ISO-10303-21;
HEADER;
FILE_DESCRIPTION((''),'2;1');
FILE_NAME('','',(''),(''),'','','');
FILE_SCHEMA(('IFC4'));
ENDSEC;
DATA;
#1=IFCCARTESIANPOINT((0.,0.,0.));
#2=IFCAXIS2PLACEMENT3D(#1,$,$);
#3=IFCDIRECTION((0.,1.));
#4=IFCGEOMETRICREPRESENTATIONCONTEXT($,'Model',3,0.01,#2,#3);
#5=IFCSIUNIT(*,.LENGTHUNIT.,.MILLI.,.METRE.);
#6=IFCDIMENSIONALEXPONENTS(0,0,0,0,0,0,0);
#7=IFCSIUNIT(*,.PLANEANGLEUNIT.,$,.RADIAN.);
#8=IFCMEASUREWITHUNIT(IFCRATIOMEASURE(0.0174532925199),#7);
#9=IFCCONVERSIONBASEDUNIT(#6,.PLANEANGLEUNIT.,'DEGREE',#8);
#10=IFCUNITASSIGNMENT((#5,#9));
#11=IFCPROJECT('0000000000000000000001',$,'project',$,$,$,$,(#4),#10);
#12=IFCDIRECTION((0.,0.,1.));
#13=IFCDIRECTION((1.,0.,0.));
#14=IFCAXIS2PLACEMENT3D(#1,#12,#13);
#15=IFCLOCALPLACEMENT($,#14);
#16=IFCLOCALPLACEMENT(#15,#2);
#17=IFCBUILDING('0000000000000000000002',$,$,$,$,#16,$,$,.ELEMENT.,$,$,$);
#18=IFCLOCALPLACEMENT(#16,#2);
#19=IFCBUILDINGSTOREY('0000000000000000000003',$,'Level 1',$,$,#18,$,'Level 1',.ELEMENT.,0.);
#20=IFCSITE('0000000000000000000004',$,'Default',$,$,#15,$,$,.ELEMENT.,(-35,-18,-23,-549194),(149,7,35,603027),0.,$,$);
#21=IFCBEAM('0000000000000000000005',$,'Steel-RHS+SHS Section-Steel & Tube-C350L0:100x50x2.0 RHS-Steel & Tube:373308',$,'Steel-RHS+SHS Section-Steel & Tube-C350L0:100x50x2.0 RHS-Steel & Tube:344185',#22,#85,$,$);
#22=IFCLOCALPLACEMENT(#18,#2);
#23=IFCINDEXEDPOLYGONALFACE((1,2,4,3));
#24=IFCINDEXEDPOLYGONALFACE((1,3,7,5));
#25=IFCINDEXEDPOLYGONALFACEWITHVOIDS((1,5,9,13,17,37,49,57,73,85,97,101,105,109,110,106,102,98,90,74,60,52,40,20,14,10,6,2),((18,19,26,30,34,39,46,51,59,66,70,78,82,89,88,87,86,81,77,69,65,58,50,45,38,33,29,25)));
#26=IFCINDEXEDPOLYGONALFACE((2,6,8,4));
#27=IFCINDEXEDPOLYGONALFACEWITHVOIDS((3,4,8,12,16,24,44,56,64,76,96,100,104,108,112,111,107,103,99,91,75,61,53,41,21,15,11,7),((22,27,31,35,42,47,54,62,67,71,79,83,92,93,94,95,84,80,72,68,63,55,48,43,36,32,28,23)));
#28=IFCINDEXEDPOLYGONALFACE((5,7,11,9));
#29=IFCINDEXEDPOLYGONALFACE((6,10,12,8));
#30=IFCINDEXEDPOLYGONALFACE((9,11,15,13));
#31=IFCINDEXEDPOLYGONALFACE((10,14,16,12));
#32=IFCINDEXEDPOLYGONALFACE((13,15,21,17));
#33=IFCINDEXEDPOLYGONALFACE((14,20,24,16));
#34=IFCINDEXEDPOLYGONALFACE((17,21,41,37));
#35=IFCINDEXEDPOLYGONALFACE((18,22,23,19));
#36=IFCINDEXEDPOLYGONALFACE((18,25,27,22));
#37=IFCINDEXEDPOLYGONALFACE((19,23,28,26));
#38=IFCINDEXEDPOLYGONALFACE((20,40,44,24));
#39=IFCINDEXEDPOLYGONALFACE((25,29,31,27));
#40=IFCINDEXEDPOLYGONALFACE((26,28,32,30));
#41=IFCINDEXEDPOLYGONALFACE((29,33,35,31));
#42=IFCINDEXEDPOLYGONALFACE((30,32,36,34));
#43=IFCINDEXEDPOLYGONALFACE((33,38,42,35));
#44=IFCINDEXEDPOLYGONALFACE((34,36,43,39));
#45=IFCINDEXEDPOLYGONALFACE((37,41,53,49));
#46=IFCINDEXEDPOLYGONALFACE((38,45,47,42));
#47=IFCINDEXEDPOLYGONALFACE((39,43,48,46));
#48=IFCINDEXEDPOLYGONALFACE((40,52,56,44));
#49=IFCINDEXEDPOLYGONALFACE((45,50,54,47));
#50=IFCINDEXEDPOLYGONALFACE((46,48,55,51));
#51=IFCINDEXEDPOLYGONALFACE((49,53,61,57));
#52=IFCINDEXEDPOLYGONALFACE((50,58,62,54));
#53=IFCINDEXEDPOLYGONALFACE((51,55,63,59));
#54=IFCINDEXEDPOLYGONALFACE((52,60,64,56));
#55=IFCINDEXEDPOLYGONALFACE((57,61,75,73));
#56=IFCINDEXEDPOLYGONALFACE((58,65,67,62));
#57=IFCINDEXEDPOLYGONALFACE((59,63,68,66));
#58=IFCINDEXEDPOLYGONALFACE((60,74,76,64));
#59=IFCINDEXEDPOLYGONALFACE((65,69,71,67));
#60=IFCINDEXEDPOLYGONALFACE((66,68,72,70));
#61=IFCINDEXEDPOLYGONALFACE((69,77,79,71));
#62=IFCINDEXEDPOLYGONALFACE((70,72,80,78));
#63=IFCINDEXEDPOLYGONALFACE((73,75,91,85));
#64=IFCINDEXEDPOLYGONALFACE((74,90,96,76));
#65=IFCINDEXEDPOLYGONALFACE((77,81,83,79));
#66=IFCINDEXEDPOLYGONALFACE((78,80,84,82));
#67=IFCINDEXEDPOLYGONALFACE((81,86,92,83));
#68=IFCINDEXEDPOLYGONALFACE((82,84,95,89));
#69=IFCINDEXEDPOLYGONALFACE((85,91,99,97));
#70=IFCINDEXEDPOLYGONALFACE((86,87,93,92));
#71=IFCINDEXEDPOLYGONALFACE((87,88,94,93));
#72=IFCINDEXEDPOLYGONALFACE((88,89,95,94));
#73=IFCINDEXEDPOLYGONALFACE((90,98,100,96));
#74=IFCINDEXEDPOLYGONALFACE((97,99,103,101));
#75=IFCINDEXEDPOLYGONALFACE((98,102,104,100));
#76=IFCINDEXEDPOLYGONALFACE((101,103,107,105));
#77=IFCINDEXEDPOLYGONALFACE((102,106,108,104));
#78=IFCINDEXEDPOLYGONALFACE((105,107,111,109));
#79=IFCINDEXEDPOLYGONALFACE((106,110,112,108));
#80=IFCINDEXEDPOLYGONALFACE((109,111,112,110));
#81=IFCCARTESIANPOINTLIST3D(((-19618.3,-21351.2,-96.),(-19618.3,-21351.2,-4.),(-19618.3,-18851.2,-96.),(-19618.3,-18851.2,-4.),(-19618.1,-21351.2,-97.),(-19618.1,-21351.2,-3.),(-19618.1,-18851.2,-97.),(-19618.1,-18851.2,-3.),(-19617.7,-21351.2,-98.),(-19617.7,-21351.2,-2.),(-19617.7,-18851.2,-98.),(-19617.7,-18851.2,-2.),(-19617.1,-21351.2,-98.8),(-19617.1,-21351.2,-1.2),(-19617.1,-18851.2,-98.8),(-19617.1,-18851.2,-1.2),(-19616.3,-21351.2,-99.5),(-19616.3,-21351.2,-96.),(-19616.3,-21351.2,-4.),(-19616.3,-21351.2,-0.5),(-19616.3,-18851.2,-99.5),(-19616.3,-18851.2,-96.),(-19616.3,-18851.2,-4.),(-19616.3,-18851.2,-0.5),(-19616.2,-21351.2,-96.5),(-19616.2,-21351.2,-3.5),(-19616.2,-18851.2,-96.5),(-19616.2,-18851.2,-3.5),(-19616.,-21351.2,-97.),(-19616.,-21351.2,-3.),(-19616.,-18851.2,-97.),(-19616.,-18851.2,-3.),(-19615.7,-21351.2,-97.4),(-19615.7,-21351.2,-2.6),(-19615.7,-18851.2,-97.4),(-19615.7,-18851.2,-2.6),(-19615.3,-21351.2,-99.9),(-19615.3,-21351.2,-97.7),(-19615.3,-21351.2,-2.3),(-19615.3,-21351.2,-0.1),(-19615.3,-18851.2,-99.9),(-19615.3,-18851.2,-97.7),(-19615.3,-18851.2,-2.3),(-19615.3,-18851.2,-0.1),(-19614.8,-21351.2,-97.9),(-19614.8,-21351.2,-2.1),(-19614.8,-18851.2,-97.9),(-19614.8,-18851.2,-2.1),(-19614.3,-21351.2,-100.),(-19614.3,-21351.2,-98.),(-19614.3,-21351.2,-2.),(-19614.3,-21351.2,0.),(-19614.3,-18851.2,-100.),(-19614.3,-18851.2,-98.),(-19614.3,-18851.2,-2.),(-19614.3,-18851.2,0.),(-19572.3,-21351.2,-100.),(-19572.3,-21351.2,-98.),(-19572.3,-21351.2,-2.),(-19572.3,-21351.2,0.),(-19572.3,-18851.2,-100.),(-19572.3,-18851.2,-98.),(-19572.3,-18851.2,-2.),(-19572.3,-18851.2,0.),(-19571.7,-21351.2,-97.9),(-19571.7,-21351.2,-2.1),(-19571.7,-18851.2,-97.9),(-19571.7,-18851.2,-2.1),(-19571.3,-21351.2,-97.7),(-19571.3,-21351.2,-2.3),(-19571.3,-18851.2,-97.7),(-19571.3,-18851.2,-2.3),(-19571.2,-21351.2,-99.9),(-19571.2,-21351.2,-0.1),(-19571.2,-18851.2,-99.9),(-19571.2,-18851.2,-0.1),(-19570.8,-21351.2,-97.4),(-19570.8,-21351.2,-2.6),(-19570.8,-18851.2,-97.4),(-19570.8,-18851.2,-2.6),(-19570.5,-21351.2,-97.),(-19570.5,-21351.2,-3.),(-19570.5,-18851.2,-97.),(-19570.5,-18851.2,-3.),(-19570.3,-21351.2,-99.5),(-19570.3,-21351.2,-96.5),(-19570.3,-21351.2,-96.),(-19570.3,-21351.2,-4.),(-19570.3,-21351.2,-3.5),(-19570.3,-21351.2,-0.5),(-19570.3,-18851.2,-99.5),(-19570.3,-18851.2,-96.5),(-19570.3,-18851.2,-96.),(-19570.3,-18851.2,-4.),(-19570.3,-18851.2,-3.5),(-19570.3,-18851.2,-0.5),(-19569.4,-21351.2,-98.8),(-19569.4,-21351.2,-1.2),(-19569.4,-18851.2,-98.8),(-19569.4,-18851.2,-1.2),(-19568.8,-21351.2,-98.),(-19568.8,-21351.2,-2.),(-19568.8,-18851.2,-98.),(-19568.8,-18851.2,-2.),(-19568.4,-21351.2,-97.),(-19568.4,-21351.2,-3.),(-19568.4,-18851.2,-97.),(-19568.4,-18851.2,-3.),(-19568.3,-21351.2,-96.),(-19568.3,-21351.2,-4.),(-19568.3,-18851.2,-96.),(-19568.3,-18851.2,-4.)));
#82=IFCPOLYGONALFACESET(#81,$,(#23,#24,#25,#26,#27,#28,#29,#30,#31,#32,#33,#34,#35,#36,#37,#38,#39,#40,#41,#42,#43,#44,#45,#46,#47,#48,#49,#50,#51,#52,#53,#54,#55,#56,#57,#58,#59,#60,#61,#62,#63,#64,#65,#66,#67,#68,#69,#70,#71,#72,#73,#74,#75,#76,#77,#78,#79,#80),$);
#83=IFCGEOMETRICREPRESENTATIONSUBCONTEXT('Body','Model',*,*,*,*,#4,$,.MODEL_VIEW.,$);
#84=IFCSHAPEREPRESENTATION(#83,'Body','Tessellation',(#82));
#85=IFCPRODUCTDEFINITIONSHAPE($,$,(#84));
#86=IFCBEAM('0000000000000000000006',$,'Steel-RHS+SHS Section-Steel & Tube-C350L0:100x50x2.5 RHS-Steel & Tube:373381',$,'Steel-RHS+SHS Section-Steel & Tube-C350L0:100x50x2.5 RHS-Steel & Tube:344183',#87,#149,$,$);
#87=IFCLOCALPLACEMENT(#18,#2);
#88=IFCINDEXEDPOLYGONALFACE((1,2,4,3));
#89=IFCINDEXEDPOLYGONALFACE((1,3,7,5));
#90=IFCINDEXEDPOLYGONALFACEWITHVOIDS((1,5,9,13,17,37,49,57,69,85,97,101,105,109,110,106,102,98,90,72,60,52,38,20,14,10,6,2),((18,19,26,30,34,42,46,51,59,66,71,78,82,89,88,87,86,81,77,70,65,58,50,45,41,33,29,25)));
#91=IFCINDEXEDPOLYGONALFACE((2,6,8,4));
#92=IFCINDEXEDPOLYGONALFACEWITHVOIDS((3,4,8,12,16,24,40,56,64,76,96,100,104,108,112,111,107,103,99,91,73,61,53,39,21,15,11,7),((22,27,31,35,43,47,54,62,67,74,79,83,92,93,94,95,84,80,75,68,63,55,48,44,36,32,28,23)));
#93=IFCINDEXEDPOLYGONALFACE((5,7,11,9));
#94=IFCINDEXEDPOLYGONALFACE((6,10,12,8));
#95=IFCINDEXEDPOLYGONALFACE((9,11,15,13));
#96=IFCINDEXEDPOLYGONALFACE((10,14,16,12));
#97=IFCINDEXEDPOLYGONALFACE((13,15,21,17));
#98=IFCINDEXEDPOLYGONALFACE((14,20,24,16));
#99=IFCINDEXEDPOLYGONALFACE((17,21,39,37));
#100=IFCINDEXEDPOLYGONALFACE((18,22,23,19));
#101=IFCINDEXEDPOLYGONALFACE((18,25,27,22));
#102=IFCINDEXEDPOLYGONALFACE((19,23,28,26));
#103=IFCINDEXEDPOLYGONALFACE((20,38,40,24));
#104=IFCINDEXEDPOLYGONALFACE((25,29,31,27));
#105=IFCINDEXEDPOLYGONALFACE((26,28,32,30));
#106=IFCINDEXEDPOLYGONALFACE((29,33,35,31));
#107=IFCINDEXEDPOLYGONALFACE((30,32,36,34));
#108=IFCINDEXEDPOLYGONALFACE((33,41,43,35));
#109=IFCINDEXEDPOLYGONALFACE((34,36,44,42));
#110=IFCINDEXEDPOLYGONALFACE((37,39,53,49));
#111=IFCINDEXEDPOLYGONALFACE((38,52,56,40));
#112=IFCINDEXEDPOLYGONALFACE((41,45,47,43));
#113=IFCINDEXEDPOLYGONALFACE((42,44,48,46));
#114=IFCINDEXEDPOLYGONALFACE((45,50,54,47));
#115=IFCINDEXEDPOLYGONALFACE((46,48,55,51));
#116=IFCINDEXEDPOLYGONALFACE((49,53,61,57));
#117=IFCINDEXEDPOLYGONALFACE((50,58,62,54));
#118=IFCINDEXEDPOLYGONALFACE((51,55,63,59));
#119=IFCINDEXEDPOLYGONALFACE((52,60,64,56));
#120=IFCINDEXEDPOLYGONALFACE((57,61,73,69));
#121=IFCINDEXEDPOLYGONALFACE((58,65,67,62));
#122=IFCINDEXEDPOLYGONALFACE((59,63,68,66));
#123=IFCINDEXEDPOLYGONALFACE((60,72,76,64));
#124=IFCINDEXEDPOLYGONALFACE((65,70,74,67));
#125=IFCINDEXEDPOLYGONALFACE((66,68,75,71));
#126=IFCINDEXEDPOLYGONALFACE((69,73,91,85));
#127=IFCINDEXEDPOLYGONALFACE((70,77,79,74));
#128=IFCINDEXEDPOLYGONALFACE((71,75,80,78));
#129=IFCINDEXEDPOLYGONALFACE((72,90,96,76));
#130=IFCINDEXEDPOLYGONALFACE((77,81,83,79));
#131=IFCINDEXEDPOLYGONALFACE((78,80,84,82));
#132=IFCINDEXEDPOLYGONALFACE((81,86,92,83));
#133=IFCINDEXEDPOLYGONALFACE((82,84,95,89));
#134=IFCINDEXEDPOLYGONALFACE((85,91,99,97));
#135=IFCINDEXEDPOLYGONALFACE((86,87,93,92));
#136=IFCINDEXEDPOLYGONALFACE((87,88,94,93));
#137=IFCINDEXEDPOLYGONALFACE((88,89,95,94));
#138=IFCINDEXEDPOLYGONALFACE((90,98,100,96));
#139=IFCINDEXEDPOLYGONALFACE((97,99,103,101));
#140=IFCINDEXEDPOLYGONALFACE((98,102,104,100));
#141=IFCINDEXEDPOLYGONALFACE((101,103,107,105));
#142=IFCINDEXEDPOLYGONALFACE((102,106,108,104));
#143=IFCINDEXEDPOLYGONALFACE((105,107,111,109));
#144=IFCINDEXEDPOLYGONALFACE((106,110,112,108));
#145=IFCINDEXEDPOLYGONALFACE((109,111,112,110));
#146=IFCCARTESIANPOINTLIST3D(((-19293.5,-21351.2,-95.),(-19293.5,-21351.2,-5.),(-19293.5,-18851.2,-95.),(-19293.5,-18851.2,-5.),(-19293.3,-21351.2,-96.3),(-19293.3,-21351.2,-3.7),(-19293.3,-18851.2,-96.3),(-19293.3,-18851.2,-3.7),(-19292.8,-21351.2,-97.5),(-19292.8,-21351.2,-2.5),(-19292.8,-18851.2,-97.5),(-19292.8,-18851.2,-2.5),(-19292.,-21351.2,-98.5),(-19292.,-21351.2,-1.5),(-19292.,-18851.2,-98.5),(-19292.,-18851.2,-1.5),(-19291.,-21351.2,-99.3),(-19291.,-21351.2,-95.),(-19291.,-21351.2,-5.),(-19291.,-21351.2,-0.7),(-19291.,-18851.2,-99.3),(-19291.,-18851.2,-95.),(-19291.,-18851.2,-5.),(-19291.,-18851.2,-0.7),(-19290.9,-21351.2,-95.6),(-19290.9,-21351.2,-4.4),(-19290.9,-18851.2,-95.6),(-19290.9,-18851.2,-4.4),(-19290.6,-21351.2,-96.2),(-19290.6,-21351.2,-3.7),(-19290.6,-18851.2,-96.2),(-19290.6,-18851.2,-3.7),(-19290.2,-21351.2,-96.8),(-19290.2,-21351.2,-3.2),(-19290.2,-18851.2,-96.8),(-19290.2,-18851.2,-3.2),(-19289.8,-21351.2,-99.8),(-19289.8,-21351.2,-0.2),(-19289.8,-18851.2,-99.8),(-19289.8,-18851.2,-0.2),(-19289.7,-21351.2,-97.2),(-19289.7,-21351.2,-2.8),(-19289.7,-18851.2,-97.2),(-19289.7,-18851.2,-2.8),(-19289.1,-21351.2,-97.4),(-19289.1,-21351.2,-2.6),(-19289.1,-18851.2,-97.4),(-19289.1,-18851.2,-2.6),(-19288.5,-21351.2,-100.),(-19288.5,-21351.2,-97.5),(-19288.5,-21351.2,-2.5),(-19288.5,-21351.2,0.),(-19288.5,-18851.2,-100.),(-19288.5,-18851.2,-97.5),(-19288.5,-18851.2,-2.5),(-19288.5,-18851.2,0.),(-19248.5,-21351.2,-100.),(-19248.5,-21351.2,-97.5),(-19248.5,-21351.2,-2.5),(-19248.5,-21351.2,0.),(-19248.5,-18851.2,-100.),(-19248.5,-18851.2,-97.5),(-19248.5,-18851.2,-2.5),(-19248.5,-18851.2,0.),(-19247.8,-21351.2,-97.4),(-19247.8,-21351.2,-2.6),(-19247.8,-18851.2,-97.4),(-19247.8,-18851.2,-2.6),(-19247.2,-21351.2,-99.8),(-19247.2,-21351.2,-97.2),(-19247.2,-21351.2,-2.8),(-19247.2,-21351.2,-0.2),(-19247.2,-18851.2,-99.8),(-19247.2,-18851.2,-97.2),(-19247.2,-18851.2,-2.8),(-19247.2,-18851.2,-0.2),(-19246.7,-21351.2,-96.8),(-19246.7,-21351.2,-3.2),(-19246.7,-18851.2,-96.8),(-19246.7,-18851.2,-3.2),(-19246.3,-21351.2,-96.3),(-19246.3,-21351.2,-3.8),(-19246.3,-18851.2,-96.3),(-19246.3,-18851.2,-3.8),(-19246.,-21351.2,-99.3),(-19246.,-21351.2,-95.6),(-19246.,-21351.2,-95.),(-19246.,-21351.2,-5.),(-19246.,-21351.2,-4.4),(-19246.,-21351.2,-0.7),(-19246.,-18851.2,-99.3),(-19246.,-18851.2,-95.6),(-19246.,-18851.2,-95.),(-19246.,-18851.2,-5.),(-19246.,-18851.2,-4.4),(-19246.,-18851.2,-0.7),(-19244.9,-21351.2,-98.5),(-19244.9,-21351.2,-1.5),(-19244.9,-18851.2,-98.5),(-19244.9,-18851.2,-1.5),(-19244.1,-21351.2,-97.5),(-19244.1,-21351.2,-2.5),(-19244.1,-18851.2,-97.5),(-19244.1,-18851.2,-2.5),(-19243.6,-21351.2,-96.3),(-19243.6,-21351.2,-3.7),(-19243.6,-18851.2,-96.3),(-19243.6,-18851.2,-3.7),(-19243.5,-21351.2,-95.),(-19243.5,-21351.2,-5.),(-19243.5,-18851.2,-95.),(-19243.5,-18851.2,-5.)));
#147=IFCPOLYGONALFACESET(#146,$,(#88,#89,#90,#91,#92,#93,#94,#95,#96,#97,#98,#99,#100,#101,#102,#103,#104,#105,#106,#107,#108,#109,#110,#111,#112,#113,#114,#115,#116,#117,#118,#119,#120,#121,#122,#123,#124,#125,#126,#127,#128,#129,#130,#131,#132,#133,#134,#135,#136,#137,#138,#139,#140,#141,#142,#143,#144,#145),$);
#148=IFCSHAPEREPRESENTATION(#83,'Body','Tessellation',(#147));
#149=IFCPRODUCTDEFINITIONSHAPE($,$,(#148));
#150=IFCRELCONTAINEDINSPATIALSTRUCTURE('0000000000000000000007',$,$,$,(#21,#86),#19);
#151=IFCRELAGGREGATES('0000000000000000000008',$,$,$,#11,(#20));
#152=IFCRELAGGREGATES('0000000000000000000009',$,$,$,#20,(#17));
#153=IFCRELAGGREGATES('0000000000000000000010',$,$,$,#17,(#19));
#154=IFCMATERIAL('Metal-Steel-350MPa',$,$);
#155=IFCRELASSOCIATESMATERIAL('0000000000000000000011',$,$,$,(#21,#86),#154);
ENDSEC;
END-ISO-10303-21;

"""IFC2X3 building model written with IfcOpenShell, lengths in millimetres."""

from ifc_helpers import new_model, entity, si_unit, converted_unit, direction, frame, frame_2d, origin, origin_with_axes, place, context, subcontext, project, spatial, polyline, circle_curve, parameter, trimmed, segment, composite_curve, outline, extrude, material, element, save


model = new_model("IFC2X3")

# Units and contexts
model_context = context("Model", 3, precision=0.01, world=origin(), true_north=direction((0.0, 1.0)))
body_context = subcontext(model_context, "Body", "Model", "MODEL_VIEW")
ifc_project = project(units=[si_unit("LENGTHUNIT", "METRE", prefix="MILLI"), converted_unit("PLANEANGLEUNIT", "DEGREE", entity("IfcRatioMeasure", 0.0174532925199), si_unit("PLANEANGLEUNIT", "RADIAN"), dimensions=[0, 0, 0, 0, 0, 0, 0])], contexts=[model_context])

# Site, building, storey
site_placement = place(None, origin_with_axes())
site = spatial("IfcSite", under=ifc_project, at=site_placement, Name="Default", CompositionType="ELEMENT", RefLatitude=(-35, -18, -23, -549194), RefLongitude=(149, 7, 35, 603027), RefElevation=0.0)
building_placement = place(site_placement, origin())
building = spatial("IfcBuilding", under=site, at=building_placement, CompositionType="ELEMENT")
storey_placement = place(building_placement, origin())
storey = spatial("IfcBuildingStorey", under=building, at=storey_placement, Name="Level 1", LongName="Level 1", CompositionType="ELEMENT", Elevation=0.0)

# Beams
ifc_material = material(Name="Metal-Steel-350MPa")
beam_1_placement = place(storey_placement, frame((-19593.3, -18851.2, 0.0), z_axis=(0.0, 0.0, 1.0), x_axis=(0.0, -1.0, 0.0)))
element("IfcBeam", 1, at=beam_1_placement, inside=storey, material=ifc_material, Name="Steel-RHS+SHS Section-Steel & Tube-C350L0:100x50x2.0 RHS-Steel & Tube:373308", ObjectType="Steel-RHS+SHS Section-Steel & Tube-C350L0:100x50x2.0 RHS-Steel & Tube:344185", context=body_context, shape_type="SweptSolid", body=[
    extrude(outline(composite_curve([segment(trimmed(circle_curve(frame_2d((-21.0, -46.0), x_axis=(1.0, 0.0)), 4.0), [parameter(180.0)], [parameter(270.0)], True, "PARAMETER"), True, "CONTINUOUS"), segment(polyline([(-21.0, -50.0), (21.0, -50.0)]), True, "CONTINUOUS"), segment(trimmed(circle_curve(frame_2d((21.0, -46.0), x_axis=(1.0, 0.0)), 4.0), [parameter(270.0)], [parameter(0.0)], True, "PARAMETER"), True, "CONTINUOUS"), segment(polyline([(25.0, -46.0), (25.0, 46.0)]), True, "CONTINUOUS"), segment(trimmed(circle_curve(frame_2d((21.0, 46.0), x_axis=(1.0, 0.0)), 4.0), [parameter(0.0)], [parameter(90.0)], True, "PARAMETER"), True, "CONTINUOUS"), segment(polyline([(21.0, 50.0), (-21.0, 50.0)]), True, "CONTINUOUS"), segment(trimmed(circle_curve(frame_2d((-21.0, 46.0), x_axis=(1.0, 0.0)), 4.0), [parameter(90.0)], [parameter(180.0)], True, "PARAMETER"), True, "CONTINUOUS"), segment(polyline([(-25.0, 46.0), (-25.0, -46.0)]), True, "CONTINUOUS")], self_intersect=False), holes=[composite_curve([segment(polyline([(21.0, -48.0), (-21.0, -48.0)]), True, "CONTINUOUS"), segment(trimmed(circle_curve(frame_2d((-21.0, -46.0), x_axis=(1.0, 0.0)), 2.0), [parameter(180.0)], [parameter(270.0)], True, "PARAMETER"), False, "CONTINUOUS"), segment(polyline([(-23.0, -46.0), (-23.0, 46.0)]), True, "CONTINUOUS"), segment(trimmed(circle_curve(frame_2d((-21.0, 46.0), x_axis=(1.0, 0.0)), 2.0), [parameter(90.0)], [parameter(180.0)], True, "PARAMETER"), False, "CONTINUOUS"), segment(polyline([(-21.0, 48.0), (21.0, 48.0)]), True, "CONTINUOUS"), segment(trimmed(circle_curve(frame_2d((21.0, 46.0), x_axis=(1.0, 0.0)), 2.0), [parameter(360.0)], [parameter(90.0)], True, "PARAMETER"), False, "CONTINUOUS"), segment(polyline([(23.0, 46.0), (23.0, -46.0)]), True, "CONTINUOUS"), segment(trimmed(circle_curve(frame_2d((21.0, -46.0), x_axis=(1.0, 0.0)), 2.0), [parameter(270.0)], [parameter(360.0)], True, "PARAMETER"), False, "CONTINUOUS")], self_intersect=False)]), frame((0.0, 0.0, -50.0), z_axis=(1.0, 0.0, 0.0), x_axis=(0.0, -1.0, 0.0)), (0.0, 0.0, 1.0), 2500.0),
])
beam_2_placement = place(storey_placement, frame((-19268.5, -18851.2, 0.0), z_axis=(0.0, 0.0, 1.0), x_axis=(0.0, -1.0, 0.0)))
element("IfcBeam", 2, at=beam_2_placement, inside=storey, material=ifc_material, Name="Steel-RHS+SHS Section-Steel & Tube-C350L0:100x50x2.5 RHS-Steel & Tube:373381", ObjectType="Steel-RHS+SHS Section-Steel & Tube-C350L0:100x50x2.5 RHS-Steel & Tube:344183", context=body_context, shape_type="SweptSolid", body=[
    extrude(outline(composite_curve([segment(trimmed(circle_curve(frame_2d((-20.0, -45.0), x_axis=(1.0, 0.0)), 5.0), [parameter(180.0)], [parameter(270.0)], True, "PARAMETER"), True, "CONTINUOUS"), segment(polyline([(-20.0, -50.0), (20.0, -50.0)]), True, "CONTINUOUS"), segment(trimmed(circle_curve(frame_2d((20.0, -45.0), x_axis=(1.0, 0.0)), 5.0), [parameter(270.0)], [parameter(0.0)], True, "PARAMETER"), True, "CONTINUOUS"), segment(polyline([(25.0, -45.0), (25.0, 45.0)]), True, "CONTINUOUS"), segment(trimmed(circle_curve(frame_2d((20.0, 45.0), x_axis=(1.0, 0.0)), 5.0), [parameter(0.0)], [parameter(90.0)], True, "PARAMETER"), True, "CONTINUOUS"), segment(polyline([(20.0, 50.0), (-20.0, 50.0)]), True, "CONTINUOUS"), segment(trimmed(circle_curve(frame_2d((-20.0, 45.0), x_axis=(1.0, 0.0)), 5.0), [parameter(90.0)], [parameter(180.0)], True, "PARAMETER"), True, "CONTINUOUS"), segment(polyline([(-25.0, 45.0), (-25.0, -45.0)]), True, "CONTINUOUS")], self_intersect=False), holes=[composite_curve([segment(polyline([(20.0, -47.5), (-20.0, -47.5)]), True, "CONTINUOUS"), segment(trimmed(circle_curve(frame_2d((-20.0, -45.0), x_axis=(1.0, 0.0)), 2.5), [parameter(180.0)], [parameter(270.0)], True, "PARAMETER"), False, "CONTINUOUS"), segment(polyline([(-22.5, -45.0), (-22.5, 45.0)]), True, "CONTINUOUS"), segment(trimmed(circle_curve(frame_2d((-20.0, 45.0), x_axis=(1.0, 0.0)), 2.5), [parameter(90.0)], [parameter(180.0)], True, "PARAMETER"), False, "CONTINUOUS"), segment(polyline([(-20.0, 47.5), (20.0, 47.5)]), True, "CONTINUOUS"), segment(trimmed(circle_curve(frame_2d((20.0, 45.0), x_axis=(1.0, 0.0)), 2.5), [parameter(360.0)], [parameter(90.0)], True, "PARAMETER"), False, "CONTINUOUS"), segment(polyline([(22.5, 45.0), (22.5, -45.0)]), True, "CONTINUOUS"), segment(trimmed(circle_curve(frame_2d((20.0, -45.0), x_axis=(1.0, 0.0)), 2.5), [parameter(270.0)], [parameter(0.0)], True, "PARAMETER"), False, "CONTINUOUS")], self_intersect=False)]), frame((0.0, 0.0, -50.0), z_axis=(1.0, 0.0, 0.0), x_axis=(0.0, -1.0, 0.0)), (0.0, 0.0, 1.0), 2500.0),
])

save(model, "model.ifc")
